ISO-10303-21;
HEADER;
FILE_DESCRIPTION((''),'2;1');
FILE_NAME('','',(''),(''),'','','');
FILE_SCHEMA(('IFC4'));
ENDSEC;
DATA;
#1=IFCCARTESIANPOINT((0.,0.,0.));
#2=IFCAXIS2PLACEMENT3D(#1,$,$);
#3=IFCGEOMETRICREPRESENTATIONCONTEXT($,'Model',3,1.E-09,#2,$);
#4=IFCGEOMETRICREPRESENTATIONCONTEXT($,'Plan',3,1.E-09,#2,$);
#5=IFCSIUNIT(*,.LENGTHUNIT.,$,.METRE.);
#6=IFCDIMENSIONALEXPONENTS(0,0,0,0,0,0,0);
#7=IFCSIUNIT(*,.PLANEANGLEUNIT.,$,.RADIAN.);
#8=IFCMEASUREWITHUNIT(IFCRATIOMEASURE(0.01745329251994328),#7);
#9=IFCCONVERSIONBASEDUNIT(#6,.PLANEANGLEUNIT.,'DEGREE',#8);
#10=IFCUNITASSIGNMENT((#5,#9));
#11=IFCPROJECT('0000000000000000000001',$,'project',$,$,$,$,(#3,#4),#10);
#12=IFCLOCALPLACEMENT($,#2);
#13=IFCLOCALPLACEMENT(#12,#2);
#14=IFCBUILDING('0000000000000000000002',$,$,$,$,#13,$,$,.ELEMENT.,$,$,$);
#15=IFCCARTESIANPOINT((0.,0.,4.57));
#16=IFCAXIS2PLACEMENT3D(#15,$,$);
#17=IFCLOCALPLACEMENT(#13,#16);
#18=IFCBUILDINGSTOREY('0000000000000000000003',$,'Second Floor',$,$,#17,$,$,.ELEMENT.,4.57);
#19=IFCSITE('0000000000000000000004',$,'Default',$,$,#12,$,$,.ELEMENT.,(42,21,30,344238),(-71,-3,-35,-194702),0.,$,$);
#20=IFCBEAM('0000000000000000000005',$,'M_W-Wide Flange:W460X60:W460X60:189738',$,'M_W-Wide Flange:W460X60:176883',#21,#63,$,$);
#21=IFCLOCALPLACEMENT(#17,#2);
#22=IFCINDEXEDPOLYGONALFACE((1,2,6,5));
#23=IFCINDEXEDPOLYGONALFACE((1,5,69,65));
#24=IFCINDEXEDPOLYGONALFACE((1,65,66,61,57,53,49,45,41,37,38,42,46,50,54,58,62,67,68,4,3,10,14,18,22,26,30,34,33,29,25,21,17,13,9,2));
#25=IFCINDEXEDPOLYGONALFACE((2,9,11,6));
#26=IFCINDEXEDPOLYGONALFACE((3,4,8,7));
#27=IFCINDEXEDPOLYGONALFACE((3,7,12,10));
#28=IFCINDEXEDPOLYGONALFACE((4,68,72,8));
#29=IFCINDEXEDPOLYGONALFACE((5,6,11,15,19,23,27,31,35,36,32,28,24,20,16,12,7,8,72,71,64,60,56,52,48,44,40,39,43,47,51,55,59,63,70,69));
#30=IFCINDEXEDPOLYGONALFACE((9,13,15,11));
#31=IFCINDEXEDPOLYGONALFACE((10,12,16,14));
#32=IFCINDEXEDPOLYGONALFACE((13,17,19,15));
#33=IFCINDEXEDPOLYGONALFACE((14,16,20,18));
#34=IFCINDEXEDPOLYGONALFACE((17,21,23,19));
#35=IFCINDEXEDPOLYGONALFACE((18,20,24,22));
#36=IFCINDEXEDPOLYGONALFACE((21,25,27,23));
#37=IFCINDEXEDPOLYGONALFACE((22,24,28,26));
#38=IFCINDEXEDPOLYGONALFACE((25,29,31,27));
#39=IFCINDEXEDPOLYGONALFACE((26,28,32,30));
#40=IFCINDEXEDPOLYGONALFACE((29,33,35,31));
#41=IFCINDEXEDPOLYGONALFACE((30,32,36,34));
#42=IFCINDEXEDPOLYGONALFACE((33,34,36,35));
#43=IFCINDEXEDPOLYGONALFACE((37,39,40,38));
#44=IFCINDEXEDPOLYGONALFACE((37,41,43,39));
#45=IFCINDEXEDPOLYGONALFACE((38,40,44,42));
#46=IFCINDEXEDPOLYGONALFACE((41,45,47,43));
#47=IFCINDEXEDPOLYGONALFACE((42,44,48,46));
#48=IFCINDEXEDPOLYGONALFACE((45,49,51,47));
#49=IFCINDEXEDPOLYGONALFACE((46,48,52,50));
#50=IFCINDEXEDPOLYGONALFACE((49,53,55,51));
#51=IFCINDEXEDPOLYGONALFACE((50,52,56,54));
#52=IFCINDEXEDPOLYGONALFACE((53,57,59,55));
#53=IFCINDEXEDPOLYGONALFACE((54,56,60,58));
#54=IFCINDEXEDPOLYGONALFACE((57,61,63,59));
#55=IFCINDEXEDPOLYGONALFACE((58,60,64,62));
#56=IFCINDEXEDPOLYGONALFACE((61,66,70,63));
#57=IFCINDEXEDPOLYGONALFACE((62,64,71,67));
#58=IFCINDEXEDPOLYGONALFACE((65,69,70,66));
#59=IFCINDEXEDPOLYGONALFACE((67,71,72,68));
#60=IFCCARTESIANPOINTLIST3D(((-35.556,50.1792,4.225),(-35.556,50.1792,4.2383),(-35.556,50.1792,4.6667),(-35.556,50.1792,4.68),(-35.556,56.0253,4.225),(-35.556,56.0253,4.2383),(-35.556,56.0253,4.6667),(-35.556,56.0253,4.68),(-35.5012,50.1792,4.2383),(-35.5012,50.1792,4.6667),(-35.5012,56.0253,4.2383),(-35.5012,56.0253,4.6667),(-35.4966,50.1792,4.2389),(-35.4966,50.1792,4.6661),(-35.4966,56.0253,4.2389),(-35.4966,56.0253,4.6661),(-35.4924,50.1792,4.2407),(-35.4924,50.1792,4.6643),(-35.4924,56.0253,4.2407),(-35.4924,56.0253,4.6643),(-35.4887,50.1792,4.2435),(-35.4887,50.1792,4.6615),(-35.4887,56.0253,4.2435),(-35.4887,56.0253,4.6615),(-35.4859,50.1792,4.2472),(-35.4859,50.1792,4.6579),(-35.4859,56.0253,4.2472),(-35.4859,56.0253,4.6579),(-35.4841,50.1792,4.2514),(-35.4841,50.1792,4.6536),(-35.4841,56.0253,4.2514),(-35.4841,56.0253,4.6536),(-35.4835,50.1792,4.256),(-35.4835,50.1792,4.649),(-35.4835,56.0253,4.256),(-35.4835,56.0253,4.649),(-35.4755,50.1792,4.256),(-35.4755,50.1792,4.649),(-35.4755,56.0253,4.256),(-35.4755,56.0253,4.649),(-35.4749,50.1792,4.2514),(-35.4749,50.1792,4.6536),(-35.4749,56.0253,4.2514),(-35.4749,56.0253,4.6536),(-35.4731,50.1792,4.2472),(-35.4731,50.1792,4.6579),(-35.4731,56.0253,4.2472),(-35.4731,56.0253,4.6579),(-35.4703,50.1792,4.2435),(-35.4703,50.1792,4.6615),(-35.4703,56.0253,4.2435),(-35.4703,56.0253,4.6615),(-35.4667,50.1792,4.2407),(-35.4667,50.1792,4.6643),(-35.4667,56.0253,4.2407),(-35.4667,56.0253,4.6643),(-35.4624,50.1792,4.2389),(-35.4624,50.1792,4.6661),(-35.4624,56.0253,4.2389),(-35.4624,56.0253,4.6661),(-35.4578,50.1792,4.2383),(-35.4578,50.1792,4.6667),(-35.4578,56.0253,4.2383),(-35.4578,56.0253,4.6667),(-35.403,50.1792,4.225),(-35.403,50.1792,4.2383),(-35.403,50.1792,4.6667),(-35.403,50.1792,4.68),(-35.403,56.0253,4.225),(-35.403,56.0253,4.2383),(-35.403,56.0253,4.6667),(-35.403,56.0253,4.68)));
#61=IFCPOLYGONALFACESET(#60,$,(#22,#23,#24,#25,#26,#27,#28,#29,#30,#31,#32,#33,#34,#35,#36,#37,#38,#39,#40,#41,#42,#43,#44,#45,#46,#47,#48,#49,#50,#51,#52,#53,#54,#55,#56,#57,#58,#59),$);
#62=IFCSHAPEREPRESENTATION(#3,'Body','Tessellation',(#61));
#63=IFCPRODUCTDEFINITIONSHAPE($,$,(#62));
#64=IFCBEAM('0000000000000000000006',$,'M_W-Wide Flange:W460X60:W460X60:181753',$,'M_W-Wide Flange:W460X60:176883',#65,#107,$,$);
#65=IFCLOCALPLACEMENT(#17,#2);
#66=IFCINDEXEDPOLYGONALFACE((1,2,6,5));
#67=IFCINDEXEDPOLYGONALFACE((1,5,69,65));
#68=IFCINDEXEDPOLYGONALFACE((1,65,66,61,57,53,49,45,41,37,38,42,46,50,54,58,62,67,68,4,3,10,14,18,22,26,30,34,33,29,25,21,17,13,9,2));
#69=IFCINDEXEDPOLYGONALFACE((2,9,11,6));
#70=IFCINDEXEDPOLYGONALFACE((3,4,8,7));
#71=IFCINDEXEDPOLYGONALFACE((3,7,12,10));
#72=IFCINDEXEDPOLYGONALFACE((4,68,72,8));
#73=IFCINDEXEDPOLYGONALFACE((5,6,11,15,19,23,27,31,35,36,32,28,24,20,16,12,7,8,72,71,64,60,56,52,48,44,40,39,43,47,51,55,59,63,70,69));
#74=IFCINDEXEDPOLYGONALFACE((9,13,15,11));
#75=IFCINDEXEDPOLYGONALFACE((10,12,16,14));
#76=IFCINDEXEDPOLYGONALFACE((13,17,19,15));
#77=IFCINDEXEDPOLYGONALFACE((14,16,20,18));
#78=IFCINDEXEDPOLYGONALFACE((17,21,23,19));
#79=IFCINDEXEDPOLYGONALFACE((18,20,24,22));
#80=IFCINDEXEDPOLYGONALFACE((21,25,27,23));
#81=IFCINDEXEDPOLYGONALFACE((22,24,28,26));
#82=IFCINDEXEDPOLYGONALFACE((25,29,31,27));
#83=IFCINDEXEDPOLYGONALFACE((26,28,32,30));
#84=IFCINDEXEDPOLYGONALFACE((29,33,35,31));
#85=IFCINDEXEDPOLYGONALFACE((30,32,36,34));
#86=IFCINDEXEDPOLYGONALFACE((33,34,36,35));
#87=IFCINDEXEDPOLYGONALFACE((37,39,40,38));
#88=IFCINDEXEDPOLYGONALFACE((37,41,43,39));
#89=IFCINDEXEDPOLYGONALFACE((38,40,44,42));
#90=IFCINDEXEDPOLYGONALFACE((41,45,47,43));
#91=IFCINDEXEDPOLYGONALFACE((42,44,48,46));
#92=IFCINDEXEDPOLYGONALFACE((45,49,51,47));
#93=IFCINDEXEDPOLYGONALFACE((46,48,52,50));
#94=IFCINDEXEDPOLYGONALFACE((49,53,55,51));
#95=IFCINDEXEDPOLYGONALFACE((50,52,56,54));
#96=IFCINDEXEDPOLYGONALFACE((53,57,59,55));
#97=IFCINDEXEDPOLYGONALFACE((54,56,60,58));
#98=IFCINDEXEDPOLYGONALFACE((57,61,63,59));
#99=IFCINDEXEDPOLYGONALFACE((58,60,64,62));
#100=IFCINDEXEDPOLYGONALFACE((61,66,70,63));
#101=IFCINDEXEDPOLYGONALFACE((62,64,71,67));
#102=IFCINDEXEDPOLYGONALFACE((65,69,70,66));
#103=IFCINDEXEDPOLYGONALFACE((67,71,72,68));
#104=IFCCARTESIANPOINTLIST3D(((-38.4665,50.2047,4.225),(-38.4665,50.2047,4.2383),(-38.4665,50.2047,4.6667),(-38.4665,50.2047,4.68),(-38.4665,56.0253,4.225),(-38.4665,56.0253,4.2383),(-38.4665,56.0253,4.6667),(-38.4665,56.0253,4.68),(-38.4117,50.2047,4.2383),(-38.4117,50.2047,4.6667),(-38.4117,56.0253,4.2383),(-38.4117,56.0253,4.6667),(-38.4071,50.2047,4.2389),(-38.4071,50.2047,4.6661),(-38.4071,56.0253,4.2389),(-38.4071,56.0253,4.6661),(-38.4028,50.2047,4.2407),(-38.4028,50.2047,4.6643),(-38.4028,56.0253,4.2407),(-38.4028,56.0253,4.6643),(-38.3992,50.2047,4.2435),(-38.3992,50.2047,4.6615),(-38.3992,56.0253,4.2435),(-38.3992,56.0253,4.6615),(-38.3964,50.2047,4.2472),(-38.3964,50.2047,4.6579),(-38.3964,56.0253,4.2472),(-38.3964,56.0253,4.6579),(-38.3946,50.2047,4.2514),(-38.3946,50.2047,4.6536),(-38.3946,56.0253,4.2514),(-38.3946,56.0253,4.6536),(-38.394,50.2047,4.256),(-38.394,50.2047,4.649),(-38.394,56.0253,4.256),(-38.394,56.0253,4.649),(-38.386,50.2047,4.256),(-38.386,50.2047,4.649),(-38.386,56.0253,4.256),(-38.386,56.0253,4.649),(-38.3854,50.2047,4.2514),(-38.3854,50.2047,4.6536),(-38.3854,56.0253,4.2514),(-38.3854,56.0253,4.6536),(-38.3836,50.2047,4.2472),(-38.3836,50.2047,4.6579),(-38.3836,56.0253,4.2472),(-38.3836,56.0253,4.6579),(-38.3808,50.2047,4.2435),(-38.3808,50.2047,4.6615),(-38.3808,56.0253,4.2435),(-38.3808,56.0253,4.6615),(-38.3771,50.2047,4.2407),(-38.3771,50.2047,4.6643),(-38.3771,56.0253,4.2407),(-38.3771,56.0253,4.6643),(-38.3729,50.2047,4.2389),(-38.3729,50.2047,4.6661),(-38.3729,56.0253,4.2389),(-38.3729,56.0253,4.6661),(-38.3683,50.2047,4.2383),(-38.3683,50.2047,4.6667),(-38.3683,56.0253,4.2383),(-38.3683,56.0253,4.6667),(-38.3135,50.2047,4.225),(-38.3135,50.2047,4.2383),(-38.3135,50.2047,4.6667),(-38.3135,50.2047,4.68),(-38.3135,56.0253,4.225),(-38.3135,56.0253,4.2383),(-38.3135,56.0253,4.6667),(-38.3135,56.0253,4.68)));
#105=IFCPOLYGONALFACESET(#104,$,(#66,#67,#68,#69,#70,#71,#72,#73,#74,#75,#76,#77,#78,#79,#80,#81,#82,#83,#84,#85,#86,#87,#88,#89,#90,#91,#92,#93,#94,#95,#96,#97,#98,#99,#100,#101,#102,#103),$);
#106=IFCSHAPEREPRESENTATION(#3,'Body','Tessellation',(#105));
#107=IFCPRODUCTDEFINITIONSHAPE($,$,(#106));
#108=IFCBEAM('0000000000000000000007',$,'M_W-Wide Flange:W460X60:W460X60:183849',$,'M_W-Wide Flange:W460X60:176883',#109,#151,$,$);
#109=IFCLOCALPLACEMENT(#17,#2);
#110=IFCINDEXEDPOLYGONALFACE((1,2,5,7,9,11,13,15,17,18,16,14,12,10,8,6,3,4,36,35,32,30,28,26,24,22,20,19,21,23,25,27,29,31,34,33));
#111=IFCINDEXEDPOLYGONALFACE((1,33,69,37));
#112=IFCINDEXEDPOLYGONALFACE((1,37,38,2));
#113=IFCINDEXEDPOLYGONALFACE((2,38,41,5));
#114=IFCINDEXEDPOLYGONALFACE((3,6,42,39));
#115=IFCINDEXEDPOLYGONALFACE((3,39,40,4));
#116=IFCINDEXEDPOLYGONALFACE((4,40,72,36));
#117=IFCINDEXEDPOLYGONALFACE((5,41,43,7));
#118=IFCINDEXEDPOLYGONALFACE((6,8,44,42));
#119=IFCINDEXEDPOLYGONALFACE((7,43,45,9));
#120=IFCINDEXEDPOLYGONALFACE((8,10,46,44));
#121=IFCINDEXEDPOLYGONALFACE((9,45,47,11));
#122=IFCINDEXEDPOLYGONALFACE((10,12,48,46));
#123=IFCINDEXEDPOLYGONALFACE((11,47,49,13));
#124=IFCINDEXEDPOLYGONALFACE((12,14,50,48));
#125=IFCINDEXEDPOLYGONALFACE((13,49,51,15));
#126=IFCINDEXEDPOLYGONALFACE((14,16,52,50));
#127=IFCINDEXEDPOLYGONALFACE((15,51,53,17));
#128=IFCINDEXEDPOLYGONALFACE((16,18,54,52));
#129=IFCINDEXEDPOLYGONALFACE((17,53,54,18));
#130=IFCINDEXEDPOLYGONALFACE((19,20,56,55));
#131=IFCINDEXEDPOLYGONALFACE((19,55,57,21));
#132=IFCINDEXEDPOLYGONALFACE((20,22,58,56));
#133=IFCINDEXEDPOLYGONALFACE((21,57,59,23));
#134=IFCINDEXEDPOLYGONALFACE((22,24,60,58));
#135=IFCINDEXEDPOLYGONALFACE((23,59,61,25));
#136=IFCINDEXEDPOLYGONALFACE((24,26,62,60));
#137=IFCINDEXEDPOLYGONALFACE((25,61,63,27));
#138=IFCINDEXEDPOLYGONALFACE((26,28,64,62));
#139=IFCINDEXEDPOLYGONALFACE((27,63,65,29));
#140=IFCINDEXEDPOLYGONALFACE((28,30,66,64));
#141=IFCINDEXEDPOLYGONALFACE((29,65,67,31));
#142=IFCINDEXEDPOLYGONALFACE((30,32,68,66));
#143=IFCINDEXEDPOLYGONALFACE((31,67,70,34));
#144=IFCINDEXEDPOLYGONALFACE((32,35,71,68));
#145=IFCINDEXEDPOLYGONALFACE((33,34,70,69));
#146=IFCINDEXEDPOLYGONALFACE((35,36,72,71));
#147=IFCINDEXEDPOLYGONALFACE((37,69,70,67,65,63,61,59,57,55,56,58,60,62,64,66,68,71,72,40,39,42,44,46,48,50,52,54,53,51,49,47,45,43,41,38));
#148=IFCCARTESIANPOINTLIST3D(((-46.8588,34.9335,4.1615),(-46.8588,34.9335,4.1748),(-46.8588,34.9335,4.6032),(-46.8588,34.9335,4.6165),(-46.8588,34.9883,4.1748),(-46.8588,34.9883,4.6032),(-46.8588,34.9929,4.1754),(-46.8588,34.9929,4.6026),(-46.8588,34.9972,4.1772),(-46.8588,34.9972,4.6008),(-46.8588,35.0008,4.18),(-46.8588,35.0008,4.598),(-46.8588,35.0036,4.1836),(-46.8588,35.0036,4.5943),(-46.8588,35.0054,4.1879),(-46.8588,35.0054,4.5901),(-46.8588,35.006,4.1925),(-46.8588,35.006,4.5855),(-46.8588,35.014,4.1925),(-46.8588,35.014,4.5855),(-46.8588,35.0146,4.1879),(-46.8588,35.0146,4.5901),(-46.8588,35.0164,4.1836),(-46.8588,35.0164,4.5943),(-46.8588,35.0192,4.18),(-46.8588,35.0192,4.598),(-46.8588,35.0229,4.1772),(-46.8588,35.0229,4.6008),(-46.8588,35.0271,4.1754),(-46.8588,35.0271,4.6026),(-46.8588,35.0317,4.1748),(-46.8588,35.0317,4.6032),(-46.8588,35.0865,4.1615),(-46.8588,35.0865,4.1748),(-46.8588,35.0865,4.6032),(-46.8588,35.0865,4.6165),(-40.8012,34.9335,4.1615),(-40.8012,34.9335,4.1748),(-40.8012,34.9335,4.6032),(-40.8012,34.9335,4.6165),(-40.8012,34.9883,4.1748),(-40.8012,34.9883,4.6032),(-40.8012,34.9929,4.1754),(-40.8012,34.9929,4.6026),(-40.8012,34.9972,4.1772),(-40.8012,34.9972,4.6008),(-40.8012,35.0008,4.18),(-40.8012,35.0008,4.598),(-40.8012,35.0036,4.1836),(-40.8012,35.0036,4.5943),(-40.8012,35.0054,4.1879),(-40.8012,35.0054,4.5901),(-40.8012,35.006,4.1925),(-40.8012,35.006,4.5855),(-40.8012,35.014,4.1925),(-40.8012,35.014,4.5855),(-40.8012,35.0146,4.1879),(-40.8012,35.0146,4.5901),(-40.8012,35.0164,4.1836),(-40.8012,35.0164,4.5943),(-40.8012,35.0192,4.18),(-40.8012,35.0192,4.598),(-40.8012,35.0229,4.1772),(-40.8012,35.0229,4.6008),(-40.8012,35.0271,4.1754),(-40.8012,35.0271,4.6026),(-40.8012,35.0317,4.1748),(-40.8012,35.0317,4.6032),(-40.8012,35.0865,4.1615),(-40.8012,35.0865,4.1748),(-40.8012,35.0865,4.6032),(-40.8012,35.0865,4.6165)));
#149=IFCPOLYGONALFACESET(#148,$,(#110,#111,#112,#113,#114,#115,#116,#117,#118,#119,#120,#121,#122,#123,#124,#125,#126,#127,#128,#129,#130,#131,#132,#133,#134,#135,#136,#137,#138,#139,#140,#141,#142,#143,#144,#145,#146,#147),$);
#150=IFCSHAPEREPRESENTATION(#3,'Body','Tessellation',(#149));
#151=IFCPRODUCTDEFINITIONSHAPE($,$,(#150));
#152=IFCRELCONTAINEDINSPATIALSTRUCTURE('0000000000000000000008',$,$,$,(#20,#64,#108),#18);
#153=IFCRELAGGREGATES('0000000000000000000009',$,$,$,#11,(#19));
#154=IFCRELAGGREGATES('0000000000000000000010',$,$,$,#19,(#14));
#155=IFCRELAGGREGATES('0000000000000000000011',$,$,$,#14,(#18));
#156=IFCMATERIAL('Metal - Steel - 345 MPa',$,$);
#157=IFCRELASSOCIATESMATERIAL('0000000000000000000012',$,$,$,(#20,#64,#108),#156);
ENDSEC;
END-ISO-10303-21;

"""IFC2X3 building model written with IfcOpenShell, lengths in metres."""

from ifc_helpers import new_model, entity, si_unit, converted_unit, frame, frame_2d, origin, place, context, project, spatial, polyline, circle_curve, parameter, trimmed, segment, composite_curve, outline, extrude, material, element, save


model = new_model("IFC2X3")

# Units and contexts
model_context = context("Model", 3, precision=1e-09, world=origin())
plan_context = context("Plan", 3, precision=1e-09, world=origin())
ifc_project = project(units=[si_unit("LENGTHUNIT", "METRE"), converted_unit("PLANEANGLEUNIT", "DEGREE", entity("IfcRatioMeasure", 0.01745329251994328), si_unit("PLANEANGLEUNIT", "RADIAN"), dimensions=[0, 0, 0, 0, 0, 0, 0])], contexts=[model_context, plan_context])

# Site, building, storey
site_placement = place(None, origin())
site = spatial("IfcSite", under=ifc_project, at=site_placement, Name="Default", CompositionType="ELEMENT", RefLatitude=(42, 21, 30, 344238), RefLongitude=(-71, -3, -35, -194702), RefElevation=0.0)
building_placement = place(site_placement, origin())
building = spatial("IfcBuilding", under=site, at=building_placement, CompositionType="ELEMENT")
storey_placement = place(building_placement, frame((0.0, 0.0, 4.57)))
storey = spatial("IfcBuildingStorey", under=building, at=storey_placement, Name="Second Floor", CompositionType="ELEMENT", Elevation=4.57)

# Shared definitions
ifc_material_1 = material(Name="Metal - Steel - 345 MPa")

# Beams
beam_1_placement = place(storey_placement, frame((-35.4795, 50.2455, 4.68)))
element("IfcBeam", 1, at=beam_1_placement, inside=storey, material=ifc_material_1, Name="M_W-Wide Flange:W460X60:W460X60:189738", ObjectType="M_W-Wide Flange:W460X60:176883", context=model_context, shape_type="SweptSolid", body=[
    extrude(outline(composite_curve([segment(polyline([(-0.0765, -0.2142), (-0.0765, -0.2275)]), True, "CONTINUOUS"), segment(polyline([(-0.0765, -0.2275), (0.0765, -0.2275)]), True, "CONTINUOUS"), segment(polyline([(0.0765, -0.2275), (0.0765, -0.2142)]), True, "CONTINUOUS"), segment(polyline([(0.0765, -0.2142), (0.0217, -0.2142)]), True, "CONTINUOUS"), segment(trimmed(circle_curve(frame_2d((0.0217, -0.1965), x_axis=(1.0, 0.0)), 0.0177), [parameter(180.0)], [parameter(270.0)], True, "PARAMETER"), False, "CONTINUOUS"), segment(polyline([(0.004, -0.1965), (0.004, 0.1965)]), True, "CONTINUOUS"), segment(trimmed(circle_curve(frame_2d((0.0217, 0.1965), x_axis=(1.0, 0.0)), 0.0177), [parameter(90.0)], [parameter(180.0)], True, "PARAMETER"), False, "CONTINUOUS"), segment(polyline([(0.0217, 0.2142), (0.0765, 0.2142)]), True, "CONTINUOUS"), segment(polyline([(0.0765, 0.2142), (0.0765, 0.2275)]), True, "CONTINUOUS"), segment(polyline([(0.0765, 0.2275), (-0.0765, 0.2275)]), True, "CONTINUOUS"), segment(polyline([(-0.0765, 0.2275), (-0.0765, 0.2142)]), True, "CONTINUOUS"), segment(polyline([(-0.0765, 0.2142), (-0.0217, 0.2142)]), True, "CONTINUOUS"), segment(trimmed(circle_curve(frame_2d((-0.0217, 0.1965), x_axis=(1.0, 0.0)), 0.0177), [parameter(360.0)], [parameter(90.0)], True, "PARAMETER"), False, "CONTINUOUS"), segment(polyline([(-0.004, 0.1965), (-0.004, -0.1965)]), True, "CONTINUOUS"), segment(trimmed(circle_curve(frame_2d((-0.0217, -0.1965), x_axis=(1.0, 0.0)), 0.0177), [parameter(270.0)], [parameter(0.0)], True, "PARAMETER"), False, "CONTINUOUS"), segment(polyline([(-0.0217, -0.2142), (-0.0765, -0.2142)]), True, "CONTINUOUS")], self_intersect=False)), frame((0.0, -0.0663, -0.2275), z_axis=(0.0, -1.0, 0.0), x_axis=(1.0, 0.0, 0.0)), (0.0, 0.0, -1.0), 5.8461),
])
beam_2_placement = place(storey_placement, frame((-38.39, 56.1369, 4.68), z_axis=(0.0, 0.0, 1.0), x_axis=(-1.0, 0.0, 0.0)))
element("IfcBeam", 2, at=beam_2_placement, inside=storey, material=ifc_material_1, Name="M_W-Wide Flange:W460X60:W460X60:181753", ObjectType="M_W-Wide Flange:W460X60:176883", context=model_context, shape_type="SweptSolid", body=[
    extrude(outline(composite_curve([segment(polyline([(0.2142, -0.0765), (0.2275, -0.0765)]), True, "CONTINUOUS"), segment(polyline([(0.2275, -0.0765), (0.2275, 0.0765)]), True, "CONTINUOUS"), segment(polyline([(0.2275, 0.0765), (0.2142, 0.0765)]), True, "CONTINUOUS"), segment(polyline([(0.2142, 0.0765), (0.2142, 0.0217)]), True, "CONTINUOUS"), segment(trimmed(circle_curve(frame_2d((0.1965, 0.0217), x_axis=(0.0, 1.0)), 0.0177), [parameter(180.0)], [parameter(270.0)], True, "PARAMETER"), False, "CONTINUOUS"), segment(polyline([(0.1965, 0.004), (-0.1965, 0.004)]), True, "CONTINUOUS"), segment(trimmed(circle_curve(frame_2d((-0.1965, 0.0217), x_axis=(0.0, 1.0)), 0.0177), [parameter(90.0)], [parameter(180.0)], True, "PARAMETER"), False, "CONTINUOUS"), segment(polyline([(-0.2142, 0.0217), (-0.2142, 0.0765)]), True, "CONTINUOUS"), segment(polyline([(-0.2142, 0.0765), (-0.2275, 0.0765)]), True, "CONTINUOUS"), segment(polyline([(-0.2275, 0.0765), (-0.2275, -0.0765)]), True, "CONTINUOUS"), segment(polyline([(-0.2275, -0.0765), (-0.2142, -0.0765)]), True, "CONTINUOUS"), segment(polyline([(-0.2142, -0.0765), (-0.2142, -0.0217)]), True, "CONTINUOUS"), segment(trimmed(circle_curve(frame_2d((-0.1965, -0.0217), x_axis=(0.0, 1.0)), 0.0177), [parameter(360.0)], [parameter(90.0)], True, "PARAMETER"), False, "CONTINUOUS"), segment(polyline([(-0.1965, -0.004), (0.1965, -0.004)]), True, "CONTINUOUS"), segment(trimmed(circle_curve(frame_2d((0.1965, -0.0217), x_axis=(0.0, 1.0)), 0.0177), [parameter(270.0)], [parameter(0.0)], True, "PARAMETER"), False, "CONTINUOUS"), segment(polyline([(0.2142, -0.0217), (0.2142, -0.0765)]), True, "CONTINUOUS")], self_intersect=False)), frame((0.0, 5.9322, -0.2275), z_axis=(0.0, -1.0, 0.0), x_axis=(0.0, 0.0, -1.0)), (0.0, 0.0, 1.0), 5.8206),
])
beam_3_placement = place(storey_placement, frame((-40.663, 35.01, 4.6165), z_axis=(0.0, 0.0, 1.0), x_axis=(0.0, 1.0, 0.0)))
element("IfcBeam", 3, at=beam_3_placement, inside=storey, material=ifc_material_1, Name="M_W-Wide Flange:W460X60:W460X60:183849", ObjectType="M_W-Wide Flange:W460X60:176883", context=model_context, shape_type="SweptSolid", body=[
    extrude(outline(composite_curve([segment(polyline([(0.2142, -0.0765), (0.2275, -0.0765)]), True, "CONTINUOUS"), segment(polyline([(0.2275, -0.0765), (0.2275, 0.0765)]), True, "CONTINUOUS"), segment(polyline([(0.2275, 0.0765), (0.2142, 0.0765)]), True, "CONTINUOUS"), segment(polyline([(0.2142, 0.0765), (0.2142, 0.0217)]), True, "CONTINUOUS"), segment(trimmed(circle_curve(frame_2d((0.1965, 0.0217), x_axis=(0.0, 1.0)), 0.0177), [parameter(180.0)], [parameter(270.0)], True, "PARAMETER"), False, "CONTINUOUS"), segment(polyline([(0.1965, 0.004), (-0.1965, 0.004)]), True, "CONTINUOUS"), segment(trimmed(circle_curve(frame_2d((-0.1965, 0.0217), x_axis=(0.0, 1.0)), 0.0177), [parameter(90.0)], [parameter(180.0)], True, "PARAMETER"), False, "CONTINUOUS"), segment(polyline([(-0.2142, 0.0217), (-0.2142, 0.0765)]), True, "CONTINUOUS"), segment(polyline([(-0.2142, 0.0765), (-0.2275, 0.0765)]), True, "CONTINUOUS"), segment(polyline([(-0.2275, 0.0765), (-0.2275, -0.0765)]), True, "CONTINUOUS"), segment(polyline([(-0.2275, -0.0765), (-0.2142, -0.0765)]), True, "CONTINUOUS"), segment(polyline([(-0.2142, -0.0765), (-0.2142, -0.0217)]), True, "CONTINUOUS"), segment(trimmed(circle_curve(frame_2d((-0.1965, -0.0217), x_axis=(0.0, 1.0)), 0.0177), [parameter(360.0)], [parameter(90.0)], True, "PARAMETER"), False, "CONTINUOUS"), segment(polyline([(-0.1965, -0.004), (0.1965, -0.004)]), True, "CONTINUOUS"), segment(trimmed(circle_curve(frame_2d((0.1965, -0.0217), x_axis=(0.0, 1.0)), 0.0177), [parameter(270.0)], [parameter(0.0)], True, "PARAMETER"), False, "CONTINUOUS"), segment(polyline([(0.2142, -0.0217), (0.2142, -0.0765)]), True, "CONTINUOUS")], self_intersect=False)), frame((0.0, 6.1958, -0.2275), z_axis=(0.0, -1.0, 0.0), x_axis=(0.0, 0.0, -1.0)), (0.0, 0.0, 1.0), 6.0576),
])

save(model, "model.ifc")
